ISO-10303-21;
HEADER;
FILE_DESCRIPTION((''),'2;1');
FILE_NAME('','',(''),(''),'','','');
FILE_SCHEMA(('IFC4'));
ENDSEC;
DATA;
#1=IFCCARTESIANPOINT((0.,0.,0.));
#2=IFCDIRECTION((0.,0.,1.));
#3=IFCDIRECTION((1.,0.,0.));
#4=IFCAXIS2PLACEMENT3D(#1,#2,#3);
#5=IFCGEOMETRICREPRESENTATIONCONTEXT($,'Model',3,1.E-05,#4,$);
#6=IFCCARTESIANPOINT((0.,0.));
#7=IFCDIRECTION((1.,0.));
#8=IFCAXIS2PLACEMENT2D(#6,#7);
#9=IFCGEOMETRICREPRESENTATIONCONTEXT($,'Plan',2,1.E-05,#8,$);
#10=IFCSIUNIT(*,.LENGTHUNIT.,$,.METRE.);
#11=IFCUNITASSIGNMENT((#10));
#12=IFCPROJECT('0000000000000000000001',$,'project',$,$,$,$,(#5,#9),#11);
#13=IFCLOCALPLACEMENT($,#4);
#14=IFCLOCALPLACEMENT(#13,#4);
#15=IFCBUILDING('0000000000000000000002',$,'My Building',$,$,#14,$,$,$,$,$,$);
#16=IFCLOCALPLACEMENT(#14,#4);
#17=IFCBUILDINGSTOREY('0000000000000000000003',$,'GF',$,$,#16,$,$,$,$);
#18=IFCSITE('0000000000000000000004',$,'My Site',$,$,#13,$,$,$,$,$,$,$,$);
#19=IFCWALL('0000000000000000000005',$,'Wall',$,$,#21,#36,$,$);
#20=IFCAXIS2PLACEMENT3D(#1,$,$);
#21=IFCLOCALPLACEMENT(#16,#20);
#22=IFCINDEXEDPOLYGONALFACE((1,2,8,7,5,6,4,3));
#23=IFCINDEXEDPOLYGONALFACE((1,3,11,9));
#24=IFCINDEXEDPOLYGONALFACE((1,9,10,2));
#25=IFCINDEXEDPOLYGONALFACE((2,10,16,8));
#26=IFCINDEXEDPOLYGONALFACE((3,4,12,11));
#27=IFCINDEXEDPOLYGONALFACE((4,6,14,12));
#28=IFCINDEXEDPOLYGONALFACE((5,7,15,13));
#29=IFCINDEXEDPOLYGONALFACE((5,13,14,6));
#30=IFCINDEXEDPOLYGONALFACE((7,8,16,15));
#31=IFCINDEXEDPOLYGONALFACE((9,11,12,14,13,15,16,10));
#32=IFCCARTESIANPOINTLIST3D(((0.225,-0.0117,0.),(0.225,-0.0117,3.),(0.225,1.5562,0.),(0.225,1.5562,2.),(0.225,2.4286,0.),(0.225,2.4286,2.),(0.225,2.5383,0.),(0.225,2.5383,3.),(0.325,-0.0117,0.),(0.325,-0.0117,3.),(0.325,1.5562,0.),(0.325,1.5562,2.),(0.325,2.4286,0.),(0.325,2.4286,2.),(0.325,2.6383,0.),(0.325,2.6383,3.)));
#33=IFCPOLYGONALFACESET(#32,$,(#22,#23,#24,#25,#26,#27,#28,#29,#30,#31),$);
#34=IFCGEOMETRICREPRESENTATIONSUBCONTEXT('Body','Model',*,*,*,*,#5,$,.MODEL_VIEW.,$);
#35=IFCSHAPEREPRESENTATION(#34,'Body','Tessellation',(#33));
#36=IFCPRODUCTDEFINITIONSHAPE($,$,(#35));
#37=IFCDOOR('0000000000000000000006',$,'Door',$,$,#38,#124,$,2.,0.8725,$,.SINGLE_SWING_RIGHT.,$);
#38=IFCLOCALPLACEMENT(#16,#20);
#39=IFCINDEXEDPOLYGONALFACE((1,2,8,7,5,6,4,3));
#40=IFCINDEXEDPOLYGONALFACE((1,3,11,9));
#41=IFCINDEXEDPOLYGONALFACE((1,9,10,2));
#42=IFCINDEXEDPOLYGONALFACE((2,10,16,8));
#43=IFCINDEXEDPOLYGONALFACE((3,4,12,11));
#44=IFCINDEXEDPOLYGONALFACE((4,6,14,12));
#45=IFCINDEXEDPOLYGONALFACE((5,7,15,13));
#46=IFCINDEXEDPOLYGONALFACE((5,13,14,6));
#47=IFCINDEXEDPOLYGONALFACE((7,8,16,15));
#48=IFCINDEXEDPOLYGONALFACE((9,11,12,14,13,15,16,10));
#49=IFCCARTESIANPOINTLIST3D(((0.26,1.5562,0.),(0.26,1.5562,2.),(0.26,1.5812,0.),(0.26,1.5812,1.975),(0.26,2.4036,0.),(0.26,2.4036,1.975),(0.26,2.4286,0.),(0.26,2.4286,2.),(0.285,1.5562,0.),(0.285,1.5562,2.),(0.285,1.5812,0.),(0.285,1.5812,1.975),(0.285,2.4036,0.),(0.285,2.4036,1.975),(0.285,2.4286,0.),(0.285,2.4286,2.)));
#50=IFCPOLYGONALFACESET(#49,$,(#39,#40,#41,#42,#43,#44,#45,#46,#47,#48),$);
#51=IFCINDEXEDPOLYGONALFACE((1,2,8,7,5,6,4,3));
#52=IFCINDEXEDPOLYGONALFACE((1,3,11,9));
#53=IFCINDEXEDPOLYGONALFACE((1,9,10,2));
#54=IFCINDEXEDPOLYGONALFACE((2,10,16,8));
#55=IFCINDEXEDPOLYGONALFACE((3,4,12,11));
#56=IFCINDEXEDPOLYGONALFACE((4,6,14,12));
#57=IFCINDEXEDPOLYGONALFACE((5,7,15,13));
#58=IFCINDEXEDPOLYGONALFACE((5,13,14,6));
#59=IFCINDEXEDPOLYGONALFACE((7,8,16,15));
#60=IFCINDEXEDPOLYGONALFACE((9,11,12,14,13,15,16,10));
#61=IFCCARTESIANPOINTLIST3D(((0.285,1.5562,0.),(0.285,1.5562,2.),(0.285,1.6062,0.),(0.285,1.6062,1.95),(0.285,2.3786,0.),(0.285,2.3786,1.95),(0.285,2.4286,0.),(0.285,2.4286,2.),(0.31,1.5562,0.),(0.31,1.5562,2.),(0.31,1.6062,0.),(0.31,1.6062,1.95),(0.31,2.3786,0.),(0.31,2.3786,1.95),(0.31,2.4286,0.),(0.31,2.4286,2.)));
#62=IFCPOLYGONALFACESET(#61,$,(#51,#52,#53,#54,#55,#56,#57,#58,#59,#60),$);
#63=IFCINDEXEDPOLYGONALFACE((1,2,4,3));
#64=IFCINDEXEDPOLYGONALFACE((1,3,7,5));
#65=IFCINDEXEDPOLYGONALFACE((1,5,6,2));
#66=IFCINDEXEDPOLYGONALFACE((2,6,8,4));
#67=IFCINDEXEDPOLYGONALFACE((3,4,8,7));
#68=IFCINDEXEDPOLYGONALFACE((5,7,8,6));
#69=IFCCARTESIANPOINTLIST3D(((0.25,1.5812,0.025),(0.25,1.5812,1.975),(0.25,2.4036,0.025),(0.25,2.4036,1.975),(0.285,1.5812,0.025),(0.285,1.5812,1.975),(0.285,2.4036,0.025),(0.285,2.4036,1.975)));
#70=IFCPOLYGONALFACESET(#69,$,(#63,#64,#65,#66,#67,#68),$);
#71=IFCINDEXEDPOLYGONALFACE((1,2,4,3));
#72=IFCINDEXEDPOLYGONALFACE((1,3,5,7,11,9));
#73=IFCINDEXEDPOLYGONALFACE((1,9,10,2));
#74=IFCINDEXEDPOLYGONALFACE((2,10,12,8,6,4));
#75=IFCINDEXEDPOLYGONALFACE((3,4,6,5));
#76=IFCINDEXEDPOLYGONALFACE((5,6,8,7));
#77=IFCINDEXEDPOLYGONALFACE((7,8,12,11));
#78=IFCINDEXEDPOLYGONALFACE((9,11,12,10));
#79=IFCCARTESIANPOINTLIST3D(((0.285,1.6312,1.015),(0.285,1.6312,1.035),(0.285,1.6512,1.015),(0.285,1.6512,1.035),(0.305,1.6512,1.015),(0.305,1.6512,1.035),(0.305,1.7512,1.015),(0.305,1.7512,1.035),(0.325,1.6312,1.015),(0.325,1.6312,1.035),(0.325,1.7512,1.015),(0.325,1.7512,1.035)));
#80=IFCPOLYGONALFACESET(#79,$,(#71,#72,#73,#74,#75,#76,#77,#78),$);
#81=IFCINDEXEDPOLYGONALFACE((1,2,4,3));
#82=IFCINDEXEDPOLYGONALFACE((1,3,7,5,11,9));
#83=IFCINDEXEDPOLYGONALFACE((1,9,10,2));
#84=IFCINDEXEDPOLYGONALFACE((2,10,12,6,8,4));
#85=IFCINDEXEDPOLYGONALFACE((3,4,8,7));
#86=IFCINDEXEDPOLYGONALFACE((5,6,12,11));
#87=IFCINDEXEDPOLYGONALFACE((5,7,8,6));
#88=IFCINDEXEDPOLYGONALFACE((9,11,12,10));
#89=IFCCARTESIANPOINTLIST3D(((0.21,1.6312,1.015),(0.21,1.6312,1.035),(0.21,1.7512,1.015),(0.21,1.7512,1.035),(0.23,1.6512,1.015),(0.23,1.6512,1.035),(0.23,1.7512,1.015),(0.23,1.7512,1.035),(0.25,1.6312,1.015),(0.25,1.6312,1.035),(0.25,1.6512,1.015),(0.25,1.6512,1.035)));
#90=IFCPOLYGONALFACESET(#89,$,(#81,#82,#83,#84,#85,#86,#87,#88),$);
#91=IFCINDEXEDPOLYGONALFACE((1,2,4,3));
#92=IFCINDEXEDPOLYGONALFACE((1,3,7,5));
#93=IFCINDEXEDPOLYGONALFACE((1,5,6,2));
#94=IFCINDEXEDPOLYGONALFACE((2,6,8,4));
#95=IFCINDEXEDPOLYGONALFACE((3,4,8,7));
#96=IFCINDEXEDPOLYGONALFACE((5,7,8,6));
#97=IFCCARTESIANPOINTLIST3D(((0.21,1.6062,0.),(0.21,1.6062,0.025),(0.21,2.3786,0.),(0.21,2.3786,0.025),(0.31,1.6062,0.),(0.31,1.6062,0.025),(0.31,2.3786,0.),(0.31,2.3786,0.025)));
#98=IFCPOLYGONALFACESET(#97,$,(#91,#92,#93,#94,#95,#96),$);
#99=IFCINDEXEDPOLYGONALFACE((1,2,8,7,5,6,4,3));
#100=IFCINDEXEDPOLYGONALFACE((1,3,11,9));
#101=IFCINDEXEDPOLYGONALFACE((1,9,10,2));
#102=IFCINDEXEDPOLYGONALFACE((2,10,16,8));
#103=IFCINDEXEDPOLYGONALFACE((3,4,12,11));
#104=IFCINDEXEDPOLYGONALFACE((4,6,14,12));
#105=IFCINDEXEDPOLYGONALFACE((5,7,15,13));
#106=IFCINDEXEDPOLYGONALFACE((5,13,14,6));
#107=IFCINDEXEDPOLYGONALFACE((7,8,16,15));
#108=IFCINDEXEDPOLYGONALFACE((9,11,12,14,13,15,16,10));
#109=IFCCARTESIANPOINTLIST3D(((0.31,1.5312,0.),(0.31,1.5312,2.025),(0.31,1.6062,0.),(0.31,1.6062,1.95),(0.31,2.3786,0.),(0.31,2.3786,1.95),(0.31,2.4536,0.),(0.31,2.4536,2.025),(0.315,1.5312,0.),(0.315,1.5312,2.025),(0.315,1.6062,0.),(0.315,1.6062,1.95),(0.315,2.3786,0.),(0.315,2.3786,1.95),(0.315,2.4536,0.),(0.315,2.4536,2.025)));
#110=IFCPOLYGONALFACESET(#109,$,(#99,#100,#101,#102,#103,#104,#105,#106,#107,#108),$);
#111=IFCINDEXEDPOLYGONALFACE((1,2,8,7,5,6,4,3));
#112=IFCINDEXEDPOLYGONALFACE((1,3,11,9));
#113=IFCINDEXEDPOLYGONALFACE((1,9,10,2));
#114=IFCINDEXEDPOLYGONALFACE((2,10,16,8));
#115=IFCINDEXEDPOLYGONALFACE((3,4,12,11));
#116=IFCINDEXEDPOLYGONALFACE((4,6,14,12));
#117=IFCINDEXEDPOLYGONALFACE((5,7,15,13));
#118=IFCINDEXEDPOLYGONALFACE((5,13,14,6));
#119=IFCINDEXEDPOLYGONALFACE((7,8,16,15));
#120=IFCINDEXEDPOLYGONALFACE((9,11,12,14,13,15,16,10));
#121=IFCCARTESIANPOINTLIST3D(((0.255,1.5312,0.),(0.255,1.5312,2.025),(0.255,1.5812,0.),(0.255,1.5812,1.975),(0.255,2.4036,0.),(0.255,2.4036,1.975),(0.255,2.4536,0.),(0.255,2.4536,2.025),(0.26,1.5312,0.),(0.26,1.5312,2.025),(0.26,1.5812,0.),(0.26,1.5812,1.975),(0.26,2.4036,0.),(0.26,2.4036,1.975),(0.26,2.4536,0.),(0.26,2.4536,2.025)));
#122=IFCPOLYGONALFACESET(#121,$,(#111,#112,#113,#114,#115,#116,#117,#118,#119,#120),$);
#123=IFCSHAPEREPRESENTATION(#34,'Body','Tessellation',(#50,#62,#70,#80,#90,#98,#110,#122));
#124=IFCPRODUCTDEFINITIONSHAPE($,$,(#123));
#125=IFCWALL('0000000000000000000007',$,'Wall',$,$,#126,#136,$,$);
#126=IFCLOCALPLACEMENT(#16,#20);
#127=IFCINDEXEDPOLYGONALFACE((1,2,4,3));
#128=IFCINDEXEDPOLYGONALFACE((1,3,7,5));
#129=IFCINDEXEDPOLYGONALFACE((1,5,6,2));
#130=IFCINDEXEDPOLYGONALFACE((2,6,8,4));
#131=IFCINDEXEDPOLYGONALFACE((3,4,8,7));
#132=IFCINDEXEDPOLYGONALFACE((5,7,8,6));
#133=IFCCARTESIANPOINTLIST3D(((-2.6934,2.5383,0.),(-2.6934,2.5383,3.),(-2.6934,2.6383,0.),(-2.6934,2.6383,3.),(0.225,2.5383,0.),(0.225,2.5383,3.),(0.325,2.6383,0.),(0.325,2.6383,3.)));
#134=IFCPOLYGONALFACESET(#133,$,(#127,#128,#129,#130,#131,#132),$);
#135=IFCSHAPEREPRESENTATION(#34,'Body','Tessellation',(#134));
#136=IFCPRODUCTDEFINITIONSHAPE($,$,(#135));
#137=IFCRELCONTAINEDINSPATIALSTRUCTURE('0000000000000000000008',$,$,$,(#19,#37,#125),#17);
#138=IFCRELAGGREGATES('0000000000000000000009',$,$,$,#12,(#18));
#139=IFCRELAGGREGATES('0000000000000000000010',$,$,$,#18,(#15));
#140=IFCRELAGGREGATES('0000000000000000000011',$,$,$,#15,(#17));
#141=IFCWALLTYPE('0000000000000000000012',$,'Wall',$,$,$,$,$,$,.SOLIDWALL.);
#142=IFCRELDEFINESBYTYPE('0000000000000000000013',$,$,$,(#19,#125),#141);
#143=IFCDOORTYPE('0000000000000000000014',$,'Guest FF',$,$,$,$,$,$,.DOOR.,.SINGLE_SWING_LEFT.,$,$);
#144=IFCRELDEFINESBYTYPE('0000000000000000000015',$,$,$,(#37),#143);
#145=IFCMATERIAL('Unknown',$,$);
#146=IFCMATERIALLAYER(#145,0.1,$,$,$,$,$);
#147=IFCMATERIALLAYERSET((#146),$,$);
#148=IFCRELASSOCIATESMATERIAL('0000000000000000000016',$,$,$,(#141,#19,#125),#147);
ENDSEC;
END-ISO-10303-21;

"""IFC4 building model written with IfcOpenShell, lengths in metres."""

from ifc_helpers import new_model, entity, si_unit, frame, origin_with_axes, origin_2d_with_axis, place, context, subcontext, project, spatial, line, indexed_curve, outline, extrude, shape, source, transform, mapped, material, layer, layer_set, layer_usage, type_object, type_shapes, element, fill, save


model = new_model("IFC4")

# Units and contexts
model_context = context("Model", 3, precision=1e-05, world=origin_with_axes())
plan_context = context("Plan", 2, precision=1e-05, world=origin_2d_with_axis())
body_context_1 = subcontext(model_context, "Body", "Model", "MODEL_VIEW")
body_context_2 = subcontext(plan_context, "Body", "Plan", "PLAN_VIEW")
ifc_project = project(units=[si_unit("LENGTHUNIT", "METRE")], contexts=[model_context, plan_context])

# Site, building, storey
site_placement = place(None, origin_with_axes())
site = spatial("IfcSite", under=ifc_project, at=site_placement, Name="My Site")
building_placement = place(site_placement, origin_with_axes())
building = spatial("IfcBuilding", under=site, at=building_placement, Name="My Building")
storey_placement = place(building_placement, origin_with_axes())
storey = spatial("IfcBuildingStorey", under=building, at=storey_placement, Name="GF")

# Shared definitions
ifc_material = material(Name="Unknown")
ifc_layer = layer(ifc_material, 0.1)
ifc_layer_set = layer_set([ifc_layer])
wall_type = type_object("IfcWallType", Name="Wall", PredefinedType="SOLIDWALL", material=ifc_layer_set)

# Wall, opening, door
ifc_layer_usage_1 = layer_usage(ifc_layer_set, "AXIS2", "POSITIVE", 0.0)
wall_1_placement = place(storey_placement, frame((0.325, -0.0117, 0.0), z_axis=(0.0, 0.0, 1.0), x_axis=(0.0, 1.0, 0.0)))
wall_1 = element("IfcWall", 1, at=wall_1_placement, inside=storey, type_object=wall_type, material=ifc_layer_usage_1, Name="Wall", context=body_context_1, shape_type="SweptSolid", body=[
    extrude(outline(indexed_curve([(0.0, 0.0), (0.0, 0.1), (2.55, 0.1), (2.65, 0.0)], segments=[line(1, 2, 3, 4, 1)])), origin_with_axes(), (0.0, 0.0, 1.0), 3.0),
])
shared_shape_1 = source(origin_with_axes(), body_context_1, "Body", "SweptSolid", [
    extrude(outline(indexed_curve([(0.0, 0.0), (0.8725, 0.0), (0.8725, 2.0), (0.0, 2.0)], segments=[line(1, 2, 3, 4, 1)])), frame((0.0, -0.6, 0.0), z_axis=(0.0, -1.0, 0.0), x_axis=(1.0, 0.0, 0.0)), (0.0, 0.0, -1.0), 1.2),
])
opening_1_placement = place(wall_1_placement, frame((1.5679, 0.015, 0.0), z_axis=(0.0, 0.0, 1.0), x_axis=(1.0, 0.0, 0.0)))
opening_1 = element("IfcOpeningElement", 2, at=opening_1_placement, cuts=wall_1, PredefinedType="OPENING", context=body_context_1, shape_type="MappedRepresentation", body=[
    mapped(shared_shape_1, transform((0.0, 0.0, 0.0), x_axis=(1.0, 0.0, 0.0), y_axis=(0.0, 1.0, 0.0), z_axis=(0.0, 0.0, 1.0), scale=1.0)),
])
door_type_1 = type_object("IfcDoorType", Name="Guest FF", OperationType="SINGLE_SWING_LEFT", PredefinedType="DOOR")
shared_shape_2 = source(origin_with_axes(), body_context_1, "Body", "SweptSolid", [
    extrude(outline(indexed_curve([(0.0, 0.0), (0.0, 2.0), (0.8725, 2.0), (0.8725, 0.0), (0.8475, 0.0), (0.8475, 1.975), (0.025, 1.975), (0.025, 0.0)], segments=[line(1, 2, 3, 4, 5, 6, 7, 8, 1)])), frame((0.0, 0.025, 0.0), z_axis=(0.0, -1.0, 0.0), x_axis=(1.0, 0.0, 0.0)), (0.0, 0.0, -1.0), 0.025),
    extrude(outline(indexed_curve([(0.0, 0.0), (0.0, 2.0), (0.8725, 2.0), (0.8725, 0.0), (0.8225, 0.0), (0.8225, 1.95), (0.05, 1.95), (0.05, 0.0)], segments=[line(1, 2, 3, 4, 5, 6, 7, 8, 1)])), frame((0.0, 0.0, 0.0), z_axis=(0.0, -1.0, 0.0), x_axis=(1.0, 0.0, 0.0)), (0.0, 0.0, -1.0), 0.025),
    extrude(outline(indexed_curve([(0.0, 0.0), (0.8225, 0.0), (0.8225, 0.035), (0.0, 0.035)], segments=[line(1, 2, 3, 4, 1)])), frame((0.025, 0.025, 0.025), z_axis=(0.0, 0.0, 1.0), x_axis=(1.0, 0.0, 0.0)), (0.0, 0.0, 1.0), 1.95),
    extrude(outline(indexed_curve([(0.0, 0.0), (0.0, -0.04), (0.12, -0.04), (0.12, -0.02), (0.02, -0.02), (0.02, 0.0)], segments=[line(1, 2, 3, 4, 5, 6, 1)])), frame((0.075, 0.025, 1.015), z_axis=(0.0, 0.0, 1.0), x_axis=(1.0, 0.0, 0.0)), (0.0, 0.0, 1.0), 0.02),
    extrude(outline(indexed_curve([(0.0, 0.0), (0.0, 0.04), (0.12, 0.04), (0.12, 0.02), (0.02, 0.02), (0.02, 0.0)], segments=[line(1, 2, 3, 4, 5, 6, 1)])), frame((0.075, 0.06, 1.015), z_axis=(0.0, 0.0, 1.0), x_axis=(1.0, 0.0, 0.0)), (0.0, 0.0, 1.0), 0.02),
    extrude(outline(indexed_curve([(0.0, 0.0), (0.7725, 0.0), (0.7725, 0.1), (0.0, 0.1)], segments=[line(1, 2, 3, 4, 1)])), frame((0.05, 0.0, 0.0), z_axis=(0.0, 0.0, 1.0), x_axis=(1.0, 0.0, 0.0)), (0.0, 0.0, 1.0), 0.025),
    extrude(outline(indexed_curve([(0.0, 0.0), (0.0, 2.025), (0.9225, 2.025), (0.9225, 0.0), (0.8475, 0.0), (0.8475, 1.95), (0.075, 1.95), (0.075, 0.0)], segments=[line(1, 2, 3, 4, 5, 6, 7, 8, 1)])), frame((-0.025, -0.005, 0.0), z_axis=(0.0, -1.0, 0.0), x_axis=(1.0, 0.0, 0.0)), (0.0, 0.0, -1.0), 0.005),
    extrude(outline(indexed_curve([(0.0, 0.0), (0.0, 2.025), (0.9225, 2.025), (0.9225, 0.0), (0.8725, 0.0), (0.8725, 1.975), (0.05, 1.975), (0.05, 0.0)], segments=[line(1, 2, 3, 4, 5, 6, 7, 8, 1)])), frame((-0.025, 0.05, 0.0), z_axis=(0.0, -1.0, 0.0), x_axis=(1.0, 0.0, 0.0)), (0.0, 0.0, -1.0), 0.005),
])
shared_shape_3 = source(origin_with_axes(), body_context_2, "Body", "Curve2D", [
    entity("IfcIndexedPolyCurve", entity("IfcCartesianPointList2D", [[0.0, 0.0], [0.0, 0.05], [0.025, 0.05], [0.025, 0.025], [0.05, 0.025], [0.05, 0.0]]), [entity("IfcLineIndex", [1, 2, 3, 4, 5, 6, 1])]),
    entity("IfcIndexedPolyCurve", entity("IfcCartesianPointList2D", [[0.8725, 0.0], [0.8725, 0.05], [0.8475, 0.05], [0.8475, 0.025], [0.8225, 0.025], [0.8225, 0.0]]), [entity("IfcLineIndex", [1, 2, 3, 4, 5, 6, 1])]),
    entity("IfcTrimmedCurve", entity("IfcEllipse", entity("IfcAxis2Placement2D", entity("IfcCartesianPoint", [0.8125, 0.05]), entity("IfcDirection", [1.0, 0.0])), 0.7875, 0.8225), [entity("IfcCartesianPoint", [0.8125, 0.8725])], [entity("IfcCartesianPoint", [0.025, 0.05])], True, "CARTESIAN"),
    entity("IfcIndexedPolyCurve", entity("IfcCartesianPointList2D", [[0.8475, 0.05], [0.8125, 0.05], [0.8125, 0.8725], [0.8475, 0.8725]]), [entity("IfcLineIndex", [1, 2, 3, 4, 1])]),
])
type_shapes(door_type_1, [shared_shape_2, shared_shape_3])
door_1_placement = place(opening_1_placement, frame((0.0, 0.0, 0.0), z_axis=(0.0, 0.0, 1.0), x_axis=(1.0, 0.0, 0.0)))
door_1 = element("IfcDoor", 3, at=door_1_placement, inside=storey, type_object=door_type_1, Name="Door", OperationType="SINGLE_SWING_RIGHT", OverallHeight=2.0, OverallWidth=0.8725, shapes=[
    shape(body_context_1, "Body", "MappedRepresentation", [mapped(shared_shape_2, transform((0.0, 0.0, 0.0), x_axis=(1.0, 0.0, 0.0), y_axis=(0.0, 1.0, 0.0), z_axis=(0.0, 0.0, 1.0), scale=1.0))]),
    shape(body_context_2, "Body", "MappedRepresentation", [mapped(shared_shape_3, transform((0.0, 0.0, 0.0), x_axis=(1.0, 0.0, 0.0), y_axis=(0.0, 1.0, 0.0), z_axis=(0.0, 0.0, 1.0), scale=1.0))]),
])
fill(opening_1, door_1)

# Wall
ifc_layer_usage_2 = layer_usage(ifc_layer_set, "AXIS2", "POSITIVE", 0.0)
wall_2_placement = place(storey_placement, frame((0.325, 2.6383, 0.0), z_axis=(0.0, 0.0, 1.0), x_axis=(-1.0, 0.0, 0.0)))
element("IfcWall", 4, at=wall_2_placement, inside=storey, type_object=wall_type, material=ifc_layer_usage_2, Name="Wall", context=body_context_1, shape_type="SweptSolid", body=[
    extrude(outline(indexed_curve([(0.0, 0.0), (0.1, 0.1), (3.0184, 0.1), (3.0184, 0.0)], segments=[line(1, 2, 3, 4, 1)])), origin_with_axes(), (0.0, 0.0, 1.0), 3.0),
])

save(model, "model.ifc")
